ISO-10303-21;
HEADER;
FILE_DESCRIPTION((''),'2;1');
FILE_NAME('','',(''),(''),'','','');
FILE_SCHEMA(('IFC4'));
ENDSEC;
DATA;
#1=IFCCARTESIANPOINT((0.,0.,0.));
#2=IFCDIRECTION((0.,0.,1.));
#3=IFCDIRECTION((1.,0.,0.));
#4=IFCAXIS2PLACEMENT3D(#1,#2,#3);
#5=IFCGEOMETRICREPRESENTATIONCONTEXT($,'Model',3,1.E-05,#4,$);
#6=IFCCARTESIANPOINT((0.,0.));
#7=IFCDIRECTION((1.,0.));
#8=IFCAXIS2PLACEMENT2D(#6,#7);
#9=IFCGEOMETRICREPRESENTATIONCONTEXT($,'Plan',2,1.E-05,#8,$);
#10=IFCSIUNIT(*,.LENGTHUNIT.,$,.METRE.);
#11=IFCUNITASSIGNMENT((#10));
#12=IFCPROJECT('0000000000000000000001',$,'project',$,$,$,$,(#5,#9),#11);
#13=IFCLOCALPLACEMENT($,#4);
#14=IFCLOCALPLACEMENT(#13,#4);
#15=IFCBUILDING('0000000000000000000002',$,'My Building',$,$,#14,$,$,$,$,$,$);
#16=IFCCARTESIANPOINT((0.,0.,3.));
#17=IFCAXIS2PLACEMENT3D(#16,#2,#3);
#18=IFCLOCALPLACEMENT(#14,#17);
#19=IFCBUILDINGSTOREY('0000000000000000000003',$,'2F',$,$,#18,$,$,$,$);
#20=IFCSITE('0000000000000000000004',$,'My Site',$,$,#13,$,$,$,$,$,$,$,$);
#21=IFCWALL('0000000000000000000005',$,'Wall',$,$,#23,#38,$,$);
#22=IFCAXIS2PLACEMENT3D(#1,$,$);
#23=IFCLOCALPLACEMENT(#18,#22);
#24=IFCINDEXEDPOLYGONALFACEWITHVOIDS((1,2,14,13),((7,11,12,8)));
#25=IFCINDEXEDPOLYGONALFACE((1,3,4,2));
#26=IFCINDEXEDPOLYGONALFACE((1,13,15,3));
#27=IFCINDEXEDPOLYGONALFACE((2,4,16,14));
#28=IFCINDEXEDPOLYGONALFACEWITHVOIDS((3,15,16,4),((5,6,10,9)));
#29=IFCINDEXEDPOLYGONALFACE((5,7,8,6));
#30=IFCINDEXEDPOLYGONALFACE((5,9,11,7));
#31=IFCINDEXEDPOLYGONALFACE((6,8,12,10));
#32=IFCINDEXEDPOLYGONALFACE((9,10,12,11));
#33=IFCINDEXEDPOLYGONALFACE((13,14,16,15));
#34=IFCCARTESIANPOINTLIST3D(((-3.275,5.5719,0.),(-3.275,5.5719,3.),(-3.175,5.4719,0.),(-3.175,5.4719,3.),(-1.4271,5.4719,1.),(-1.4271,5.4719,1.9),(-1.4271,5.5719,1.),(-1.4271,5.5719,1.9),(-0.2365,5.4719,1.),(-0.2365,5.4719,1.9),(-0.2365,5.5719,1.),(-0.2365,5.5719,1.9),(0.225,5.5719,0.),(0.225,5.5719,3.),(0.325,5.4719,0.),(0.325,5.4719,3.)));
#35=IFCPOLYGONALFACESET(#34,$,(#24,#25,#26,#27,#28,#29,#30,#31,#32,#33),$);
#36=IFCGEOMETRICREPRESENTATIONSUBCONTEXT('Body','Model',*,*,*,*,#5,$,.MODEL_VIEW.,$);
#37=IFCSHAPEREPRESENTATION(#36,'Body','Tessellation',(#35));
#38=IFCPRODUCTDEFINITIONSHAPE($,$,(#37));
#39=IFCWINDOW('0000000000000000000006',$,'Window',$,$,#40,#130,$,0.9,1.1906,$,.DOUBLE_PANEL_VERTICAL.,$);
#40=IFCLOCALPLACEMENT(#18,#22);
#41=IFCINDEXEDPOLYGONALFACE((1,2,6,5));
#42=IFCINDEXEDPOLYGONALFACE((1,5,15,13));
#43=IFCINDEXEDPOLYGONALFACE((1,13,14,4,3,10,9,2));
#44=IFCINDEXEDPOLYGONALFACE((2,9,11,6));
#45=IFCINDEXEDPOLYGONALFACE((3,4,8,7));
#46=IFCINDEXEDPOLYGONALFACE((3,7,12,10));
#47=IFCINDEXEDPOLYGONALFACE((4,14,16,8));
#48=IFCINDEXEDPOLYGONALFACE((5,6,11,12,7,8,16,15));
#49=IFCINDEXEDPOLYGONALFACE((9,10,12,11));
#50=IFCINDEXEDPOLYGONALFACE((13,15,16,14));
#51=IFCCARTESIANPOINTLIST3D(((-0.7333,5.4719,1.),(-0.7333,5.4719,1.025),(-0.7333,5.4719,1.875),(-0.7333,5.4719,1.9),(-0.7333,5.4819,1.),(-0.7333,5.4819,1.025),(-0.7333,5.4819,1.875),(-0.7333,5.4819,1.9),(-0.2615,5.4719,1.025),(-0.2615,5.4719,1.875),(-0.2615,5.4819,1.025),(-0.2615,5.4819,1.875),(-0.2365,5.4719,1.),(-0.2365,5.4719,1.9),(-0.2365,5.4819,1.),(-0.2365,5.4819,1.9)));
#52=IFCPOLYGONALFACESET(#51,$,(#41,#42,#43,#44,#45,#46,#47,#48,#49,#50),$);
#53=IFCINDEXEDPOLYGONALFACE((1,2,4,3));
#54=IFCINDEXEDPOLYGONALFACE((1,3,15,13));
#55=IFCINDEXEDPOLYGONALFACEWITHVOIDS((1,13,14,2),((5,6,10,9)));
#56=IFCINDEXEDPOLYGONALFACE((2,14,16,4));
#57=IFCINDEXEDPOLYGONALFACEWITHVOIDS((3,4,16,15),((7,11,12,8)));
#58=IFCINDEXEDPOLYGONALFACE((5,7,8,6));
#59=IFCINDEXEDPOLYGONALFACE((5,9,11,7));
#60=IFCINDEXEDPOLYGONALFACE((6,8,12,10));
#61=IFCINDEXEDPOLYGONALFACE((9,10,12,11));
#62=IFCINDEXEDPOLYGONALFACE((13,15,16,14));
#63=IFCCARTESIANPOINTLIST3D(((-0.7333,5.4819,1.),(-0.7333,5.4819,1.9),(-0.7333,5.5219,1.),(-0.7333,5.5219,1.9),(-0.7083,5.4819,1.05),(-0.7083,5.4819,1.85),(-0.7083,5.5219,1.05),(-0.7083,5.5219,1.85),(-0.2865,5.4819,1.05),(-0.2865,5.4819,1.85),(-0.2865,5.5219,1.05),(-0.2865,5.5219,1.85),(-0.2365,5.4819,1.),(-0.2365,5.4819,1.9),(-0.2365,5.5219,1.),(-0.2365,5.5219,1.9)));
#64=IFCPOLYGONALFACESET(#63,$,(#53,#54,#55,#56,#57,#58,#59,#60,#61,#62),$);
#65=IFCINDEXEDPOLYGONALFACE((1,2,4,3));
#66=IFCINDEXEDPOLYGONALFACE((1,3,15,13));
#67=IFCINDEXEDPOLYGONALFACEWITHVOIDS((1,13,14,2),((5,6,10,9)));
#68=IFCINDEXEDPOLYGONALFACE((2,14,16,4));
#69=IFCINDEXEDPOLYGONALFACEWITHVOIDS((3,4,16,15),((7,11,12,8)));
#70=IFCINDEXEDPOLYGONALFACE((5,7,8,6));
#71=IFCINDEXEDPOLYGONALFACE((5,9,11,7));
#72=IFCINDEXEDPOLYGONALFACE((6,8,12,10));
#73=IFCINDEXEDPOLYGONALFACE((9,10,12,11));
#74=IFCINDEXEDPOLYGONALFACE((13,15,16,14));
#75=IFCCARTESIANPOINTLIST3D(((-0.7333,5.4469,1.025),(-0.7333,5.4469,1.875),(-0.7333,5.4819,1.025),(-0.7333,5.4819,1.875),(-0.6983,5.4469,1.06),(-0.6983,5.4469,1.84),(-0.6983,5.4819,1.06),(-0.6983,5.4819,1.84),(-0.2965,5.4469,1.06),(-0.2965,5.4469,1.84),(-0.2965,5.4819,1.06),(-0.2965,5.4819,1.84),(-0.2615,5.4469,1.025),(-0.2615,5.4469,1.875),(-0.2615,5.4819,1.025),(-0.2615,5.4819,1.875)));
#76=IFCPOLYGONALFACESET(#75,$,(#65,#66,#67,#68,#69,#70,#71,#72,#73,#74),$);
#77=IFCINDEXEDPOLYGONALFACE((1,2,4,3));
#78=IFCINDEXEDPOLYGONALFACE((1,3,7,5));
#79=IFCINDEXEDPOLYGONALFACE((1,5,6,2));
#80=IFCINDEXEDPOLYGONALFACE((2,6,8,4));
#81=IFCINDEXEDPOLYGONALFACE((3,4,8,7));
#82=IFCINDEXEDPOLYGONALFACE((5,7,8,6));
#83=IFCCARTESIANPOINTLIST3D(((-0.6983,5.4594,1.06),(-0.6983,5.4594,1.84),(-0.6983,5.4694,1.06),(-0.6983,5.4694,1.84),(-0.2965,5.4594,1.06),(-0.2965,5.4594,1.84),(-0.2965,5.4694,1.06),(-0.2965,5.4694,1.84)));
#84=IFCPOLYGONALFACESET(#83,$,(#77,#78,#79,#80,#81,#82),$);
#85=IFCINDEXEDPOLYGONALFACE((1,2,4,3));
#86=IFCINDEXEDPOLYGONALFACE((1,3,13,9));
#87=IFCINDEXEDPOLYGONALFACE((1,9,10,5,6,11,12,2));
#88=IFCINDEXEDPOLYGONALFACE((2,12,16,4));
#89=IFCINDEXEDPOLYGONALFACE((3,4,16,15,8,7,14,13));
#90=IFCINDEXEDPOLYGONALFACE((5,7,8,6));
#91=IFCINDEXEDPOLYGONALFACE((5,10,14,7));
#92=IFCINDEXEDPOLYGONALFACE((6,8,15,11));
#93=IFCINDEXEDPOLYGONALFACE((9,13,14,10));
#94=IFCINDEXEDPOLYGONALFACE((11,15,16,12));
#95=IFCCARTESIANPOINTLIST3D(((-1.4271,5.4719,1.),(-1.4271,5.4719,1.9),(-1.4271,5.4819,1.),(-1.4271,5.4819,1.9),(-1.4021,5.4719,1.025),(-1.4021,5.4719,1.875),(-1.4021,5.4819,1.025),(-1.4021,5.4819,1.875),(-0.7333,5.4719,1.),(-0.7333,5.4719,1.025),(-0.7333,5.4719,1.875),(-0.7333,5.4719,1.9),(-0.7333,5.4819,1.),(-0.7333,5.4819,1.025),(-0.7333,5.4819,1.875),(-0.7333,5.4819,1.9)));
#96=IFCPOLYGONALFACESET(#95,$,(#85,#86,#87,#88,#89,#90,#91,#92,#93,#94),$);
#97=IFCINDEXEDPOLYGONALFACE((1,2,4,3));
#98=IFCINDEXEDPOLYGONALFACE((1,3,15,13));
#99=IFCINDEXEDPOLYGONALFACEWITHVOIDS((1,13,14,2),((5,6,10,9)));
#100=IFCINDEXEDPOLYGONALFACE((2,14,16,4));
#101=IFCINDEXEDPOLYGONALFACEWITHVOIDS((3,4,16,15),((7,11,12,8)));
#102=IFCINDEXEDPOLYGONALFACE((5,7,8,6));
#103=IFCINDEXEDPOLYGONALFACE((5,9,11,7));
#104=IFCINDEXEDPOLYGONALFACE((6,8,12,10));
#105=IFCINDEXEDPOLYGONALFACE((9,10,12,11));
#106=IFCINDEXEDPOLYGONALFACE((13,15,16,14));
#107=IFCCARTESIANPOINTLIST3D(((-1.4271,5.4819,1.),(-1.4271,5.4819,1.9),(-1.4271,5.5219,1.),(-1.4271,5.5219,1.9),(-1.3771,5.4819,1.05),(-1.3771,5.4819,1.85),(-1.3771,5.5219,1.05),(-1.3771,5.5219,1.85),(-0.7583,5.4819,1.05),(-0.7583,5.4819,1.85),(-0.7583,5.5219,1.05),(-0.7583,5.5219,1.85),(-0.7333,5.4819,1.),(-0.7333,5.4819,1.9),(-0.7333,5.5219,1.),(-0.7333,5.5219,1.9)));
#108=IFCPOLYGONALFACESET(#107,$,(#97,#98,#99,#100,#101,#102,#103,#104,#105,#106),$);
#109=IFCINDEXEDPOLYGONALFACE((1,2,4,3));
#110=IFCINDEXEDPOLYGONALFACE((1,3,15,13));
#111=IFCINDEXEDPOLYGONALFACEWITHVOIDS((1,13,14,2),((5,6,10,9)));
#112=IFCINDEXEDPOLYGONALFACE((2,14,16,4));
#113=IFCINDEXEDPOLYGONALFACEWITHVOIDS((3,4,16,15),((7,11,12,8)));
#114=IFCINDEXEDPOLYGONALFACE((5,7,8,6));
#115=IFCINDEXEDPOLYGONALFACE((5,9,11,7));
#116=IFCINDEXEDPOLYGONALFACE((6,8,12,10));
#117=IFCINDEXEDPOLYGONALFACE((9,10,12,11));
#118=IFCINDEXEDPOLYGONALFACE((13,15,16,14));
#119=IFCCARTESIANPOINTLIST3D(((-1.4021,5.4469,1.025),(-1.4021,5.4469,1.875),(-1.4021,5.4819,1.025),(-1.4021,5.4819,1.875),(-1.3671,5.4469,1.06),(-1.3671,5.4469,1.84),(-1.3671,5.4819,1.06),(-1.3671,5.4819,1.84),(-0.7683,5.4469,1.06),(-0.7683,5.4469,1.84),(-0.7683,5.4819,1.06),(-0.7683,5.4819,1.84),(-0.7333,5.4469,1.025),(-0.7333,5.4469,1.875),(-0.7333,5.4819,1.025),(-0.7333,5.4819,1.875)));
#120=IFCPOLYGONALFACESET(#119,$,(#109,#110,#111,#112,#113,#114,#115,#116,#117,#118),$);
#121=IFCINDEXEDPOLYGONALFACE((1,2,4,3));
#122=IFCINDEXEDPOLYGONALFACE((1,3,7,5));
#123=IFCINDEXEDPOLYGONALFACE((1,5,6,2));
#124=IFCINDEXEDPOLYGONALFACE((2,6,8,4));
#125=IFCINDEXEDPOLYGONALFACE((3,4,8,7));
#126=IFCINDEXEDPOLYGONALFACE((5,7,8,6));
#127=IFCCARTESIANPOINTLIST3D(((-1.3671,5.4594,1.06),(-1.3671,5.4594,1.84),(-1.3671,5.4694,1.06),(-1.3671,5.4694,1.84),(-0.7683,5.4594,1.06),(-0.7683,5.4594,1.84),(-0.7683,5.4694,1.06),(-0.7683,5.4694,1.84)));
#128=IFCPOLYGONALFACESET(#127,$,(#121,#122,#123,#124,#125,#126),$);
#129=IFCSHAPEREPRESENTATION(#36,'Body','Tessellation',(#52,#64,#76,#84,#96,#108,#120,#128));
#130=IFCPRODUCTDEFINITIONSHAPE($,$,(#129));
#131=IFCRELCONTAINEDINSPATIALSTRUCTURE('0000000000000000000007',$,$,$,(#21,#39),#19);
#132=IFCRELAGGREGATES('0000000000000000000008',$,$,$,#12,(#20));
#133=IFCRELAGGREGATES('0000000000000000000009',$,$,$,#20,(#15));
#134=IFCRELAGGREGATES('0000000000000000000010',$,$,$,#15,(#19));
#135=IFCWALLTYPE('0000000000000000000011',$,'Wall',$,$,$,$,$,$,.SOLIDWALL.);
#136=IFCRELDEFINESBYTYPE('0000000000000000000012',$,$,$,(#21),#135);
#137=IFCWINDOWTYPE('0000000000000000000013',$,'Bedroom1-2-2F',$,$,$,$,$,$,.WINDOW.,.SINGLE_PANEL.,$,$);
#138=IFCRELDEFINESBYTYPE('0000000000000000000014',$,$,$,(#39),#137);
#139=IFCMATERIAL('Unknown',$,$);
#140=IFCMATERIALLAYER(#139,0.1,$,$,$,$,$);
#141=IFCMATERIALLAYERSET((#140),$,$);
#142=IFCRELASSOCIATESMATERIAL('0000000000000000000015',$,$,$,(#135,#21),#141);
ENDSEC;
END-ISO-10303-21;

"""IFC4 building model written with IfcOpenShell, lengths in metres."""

from ifc_helpers import new_model, entity, si_unit, frame, origin_with_axes, origin_2d_with_axis, place, context, subcontext, project, spatial, line, indexed_curve, outline, extrude, shape, source, transform, mapped, material, layer, layer_set, layer_usage, type_object, type_shapes, element, fill, save


model = new_model("IFC4")

# Units and contexts
model_context = context("Model", 3, precision=1e-05, world=origin_with_axes())
plan_context = context("Plan", 2, precision=1e-05, world=origin_2d_with_axis())
body_context_1 = subcontext(model_context, "Body", "Model", "MODEL_VIEW")
body_context_2 = subcontext(plan_context, "Body", "Plan", "PLAN_VIEW")
ifc_project = project(units=[si_unit("LENGTHUNIT", "METRE")], contexts=[model_context, plan_context])

# Site, building, storey
site_placement = place(None, origin_with_axes())
site = spatial("IfcSite", under=ifc_project, at=site_placement, Name="My Site")
building_placement = place(site_placement, origin_with_axes())
building = spatial("IfcBuilding", under=site, at=building_placement, Name="My Building")
storey_placement = place(building_placement, frame((0.0, 0.0, 3.0), z_axis=(0.0, 0.0, 1.0), x_axis=(1.0, 0.0, 0.0)))
storey = spatial("IfcBuildingStorey", under=building, at=storey_placement, Name="2F")

# Shared definitions
ifc_material = material(Name="Unknown")

# Shared definitions
ifc_layer = layer(ifc_material, 0.1)
ifc_layer_set = layer_set([ifc_layer])
wall_type = type_object("IfcWallType", Name="Wall", PredefinedType="SOLIDWALL", material=ifc_layer_set)

# Wall, opening, window
ifc_layer_usage_1 = layer_usage(ifc_layer_set, "AXIS2", "POSITIVE", 0.0)
wall_1_placement = place(storey_placement, frame((0.225, 5.5719, 0.0), z_axis=(0.0, 0.0, 1.0), x_axis=(-1.0, 0.0, 0.0)))
wall_1 = element("IfcWall", 1, at=wall_1_placement, inside=storey, type_object=wall_type, material=ifc_layer_usage_1, Name="Wall", context=body_context_1, shape_type="SweptSolid", body=[
    extrude(outline(indexed_curve([(0.0, 0.0), (-0.1, 0.1), (3.4, 0.1), (3.5, 0.0)], segments=[line(1, 2, 3, 4, 1)])), origin_with_axes(), (0.0, 0.0, 1.0), 3.0),
])
shared_shape_1 = source(origin_with_axes(), body_context_1, "Body", "SweptSolid", [
    extrude(outline(indexed_curve([(0.0, 0.0), (1.1906, 0.0), (1.1906, 0.9), (0.0, 0.9)], segments=[line(1, 2, 3, 4, 1)])), frame((0.0, -0.6, 0.0), z_axis=(0.0, -1.0, 0.0), x_axis=(1.0, 0.0, 0.0)), (0.0, 0.0, -1.0), 1.2),
])
opening_1_placement = place(wall_1_placement, frame((0.4615, 0.0, 1.0), z_axis=(0.0, 0.0, 1.0), x_axis=(1.0, 0.0, 0.0)))
opening_1 = element("IfcOpeningElement", 2, at=opening_1_placement, cuts=wall_1, PredefinedType="OPENING", context=body_context_1, shape_type="MappedRepresentation", body=[
    mapped(shared_shape_1, transform((0.0, 0.0, 0.0), x_axis=(1.0, 0.0, 0.0), y_axis=(0.0, 1.0, 0.0), z_axis=(0.0, 0.0, 1.0), scale=1.0)),
])
window_type_1 = type_object("IfcWindowType", Name="Bedroom1-2-2F", PartitioningType="SINGLE_PANEL", PredefinedType="WINDOW")
shared_shape_2 = source(origin_with_axes(), body_context_1, "Body", "SweptSolid", [
    extrude(outline(indexed_curve([(0.4967, 0.0), (0.0, 0.0), (0.0, 0.9), (0.4967, 0.9), (0.4967, 0.875), (0.025, 0.875), (0.025, 0.025), (0.4967, 0.025)], segments=[line(1, 2, 3, 4, 5, 6, 7, 8, 1)])), frame((0.0, 0.09, 0.0), z_axis=(0.0, -1.0, 0.0), x_axis=(1.0, 0.0, 0.0)), (0.0, 0.0, -1.0), 0.01),
    extrude(outline(indexed_curve([(0.0, 0.0), (0.4967, 0.0), (0.4967, 0.9), (0.0, 0.9)], segments=[line(1, 2, 3, 4, 1)]), holes=[indexed_curve([(0.05, 0.05), (0.4717, 0.05), (0.4717, 0.85), (0.05, 0.85)], segments=[line(1, 2, 3, 4, 1)])]), frame((0.0, 0.05, 0.0), z_axis=(0.0, -1.0, 0.0), x_axis=(1.0, 0.0, 0.0)), (0.0, 0.0, -1.0), 0.04),
    extrude(outline(indexed_curve([(0.0, 0.0), (0.4717, 0.0), (0.4717, 0.85), (0.0, 0.85)], segments=[line(1, 2, 3, 4, 1)]), holes=[indexed_curve([(0.035, 0.035), (0.4367, 0.035), (0.4367, 0.815), (0.035, 0.815)], segments=[line(1, 2, 3, 4, 1)])]), frame((0.025, 0.09, 0.025), z_axis=(0.0, -1.0, 0.0), x_axis=(1.0, 0.0, 0.0)), (0.0, 0.0, -1.0), 0.035),
    extrude(outline(indexed_curve([(0.035, 0.035), (0.4367, 0.035), (0.4367, 0.815), (0.035, 0.815)], segments=[line(1, 2, 3, 4, 1)])), frame((0.025, 0.1025, 0.025), z_axis=(0.0, -1.0, 0.0), x_axis=(1.0, 0.0, 0.0)), (0.0, 0.0, -1.0), 0.01),
    extrude(outline(indexed_curve([(0.0, 0.9), (0.6938, 0.9), (0.6938, 0.0), (0.0, 0.0), (0.0, 0.025), (0.6688, 0.025), (0.6688, 0.875), (0.0, 0.875)], segments=[line(1, 2, 3, 4, 5, 6, 7, 8, 1)])), frame((0.4967, 0.09, 0.0), z_axis=(0.0, -1.0, 0.0), x_axis=(1.0, 0.0, 0.0)), (0.0, 0.0, -1.0), 0.01),
    extrude(outline(indexed_curve([(0.0, 0.0), (0.6938, 0.0), (0.6938, 0.9), (0.0, 0.9)], segments=[line(1, 2, 3, 4, 1)]), holes=[indexed_curve([(0.025, 0.05), (0.6438, 0.05), (0.6438, 0.85), (0.025, 0.85)], segments=[line(1, 2, 3, 4, 1)])]), frame((0.4967, 0.05, 0.0), z_axis=(0.0, -1.0, 0.0), x_axis=(1.0, 0.0, 0.0)), (0.0, 0.0, -1.0), 0.04),
    extrude(outline(indexed_curve([(0.0, 0.0), (0.6688, 0.0), (0.6688, 0.85), (0.0, 0.85)], segments=[line(1, 2, 3, 4, 1)]), holes=[indexed_curve([(0.035, 0.035), (0.6338, 0.035), (0.6338, 0.815), (0.035, 0.815)], segments=[line(1, 2, 3, 4, 1)])]), frame((0.4967, 0.09, 0.025), z_axis=(0.0, -1.0, 0.0), x_axis=(1.0, 0.0, 0.0)), (0.0, 0.0, -1.0), 0.035),
    extrude(outline(indexed_curve([(0.035, 0.035), (0.6338, 0.035), (0.6338, 0.815), (0.035, 0.815)], segments=[line(1, 2, 3, 4, 1)])), frame((0.4967, 0.1025, 0.025), z_axis=(0.0, -1.0, 0.0), x_axis=(1.0, 0.0, 0.0)), (0.0, 0.0, -1.0), 0.01),
])
shared_shape_3 = source(origin_with_axes(), body_context_2, "Body", "Curve2D", [
    entity("IfcIndexedPolyCurve", entity("IfcCartesianPointList2D", [[0.05, 0.05], [0.4717, 0.05]])),
    entity("IfcIndexedPolyCurve", entity("IfcCartesianPointList2D", [[0.0, 0.1], [0.025, 0.1], [0.025, 0.09], [0.05, 0.09], [0.05, 0.05], [0.0, 0.05]]), [entity("IfcLineIndex", [1, 2, 3, 4, 5, 6, 1])]),
    entity("IfcIndexedPolyCurve", entity("IfcCartesianPointList2D", [[0.4967, 0.1], [0.4967, 0.1], [0.4967, 0.09], [0.4717, 0.09], [0.4717, 0.05], [0.4967, 0.05]])),
    entity("IfcIndexedPolyCurve", entity("IfcCartesianPointList2D", [[0.025, 0.09], [0.06, 0.09], [0.06, 0.125], [0.025, 0.125]]), [entity("IfcLineIndex", [1, 2, 3, 4, 1])]),
    entity("IfcIndexedPolyCurve", entity("IfcCartesianPointList2D", [[0.4967, 0.09], [0.4617, 0.09], [0.4617, 0.125], [0.4967, 0.125]]), [entity("IfcLineIndex", [1, 2, 3, 4, 1])]),
    entity("IfcIndexedPolyCurve", entity("IfcCartesianPointList2D", [[0.06, 0.09], [0.4617, 0.09]])),
    entity("IfcIndexedPolyCurve", entity("IfcCartesianPointList2D", [[0.06, 0.125], [0.4617, 0.125]])),
    entity("IfcIndexedPolyCurve", entity("IfcCartesianPointList2D", [[0.06, 0.1075], [0.4617, 0.1075]])),
    entity("IfcIndexedPolyCurve", entity("IfcCartesianPointList2D", [[0.5217, 0.05], [1.1406, 0.05]])),
    entity("IfcIndexedPolyCurve", entity("IfcCartesianPointList2D", [[0.4967, 0.1], [0.4967, 0.1], [0.4967, 0.09], [0.5217, 0.09], [0.5217, 0.05], [0.4967, 0.05]])),
    entity("IfcIndexedPolyCurve", entity("IfcCartesianPointList2D", [[1.1906, 0.1], [1.1656, 0.1], [1.1656, 0.09], [1.1406, 0.09], [1.1406, 0.05], [1.1906, 0.05]]), [entity("IfcLineIndex", [1, 2, 3, 4, 5, 6, 1])]),
    entity("IfcIndexedPolyCurve", entity("IfcCartesianPointList2D", [[0.4967, 0.09], [0.5317, 0.09], [0.5317, 0.125], [0.4967, 0.125]]), [entity("IfcLineIndex", [1, 2, 3, 4, 1])]),
    entity("IfcIndexedPolyCurve", entity("IfcCartesianPointList2D", [[1.1656, 0.09], [1.1306, 0.09], [1.1306, 0.125], [1.1656, 0.125]]), [entity("IfcLineIndex", [1, 2, 3, 4, 1])]),
    entity("IfcIndexedPolyCurve", entity("IfcCartesianPointList2D", [[0.5317, 0.09], [1.1306, 0.09]])),
    entity("IfcIndexedPolyCurve", entity("IfcCartesianPointList2D", [[0.5317, 0.125], [1.1306, 0.125]])),
    entity("IfcIndexedPolyCurve", entity("IfcCartesianPointList2D", [[0.5317, 0.1075], [1.1306, 0.1075]])),
])
type_shapes(window_type_1, [shared_shape_2, shared_shape_3])
window_1_placement = place(opening_1_placement, origin_with_axes())
window_1 = element("IfcWindow", 3, at=window_1_placement, inside=storey, type_object=window_type_1, Name="Window", OverallHeight=0.9, OverallWidth=1.1906, PartitioningType="DOUBLE_PANEL_VERTICAL", shapes=[
    shape(body_context_1, "Body", "MappedRepresentation", [mapped(shared_shape_2, transform((0.0, 0.0, 0.0), x_axis=(1.0, 0.0, 0.0), y_axis=(0.0, 1.0, 0.0), z_axis=(0.0, 0.0, 1.0), scale=1.0))]),
    shape(body_context_2, "Body", "MappedRepresentation", [mapped(shared_shape_3, transform((0.0, 0.0, 0.0), x_axis=(1.0, 0.0, 0.0), y_axis=(0.0, 1.0, 0.0), z_axis=(0.0, 0.0, 1.0), scale=1.0))]),
])
fill(opening_1, window_1)

save(model, "model.ifc")
